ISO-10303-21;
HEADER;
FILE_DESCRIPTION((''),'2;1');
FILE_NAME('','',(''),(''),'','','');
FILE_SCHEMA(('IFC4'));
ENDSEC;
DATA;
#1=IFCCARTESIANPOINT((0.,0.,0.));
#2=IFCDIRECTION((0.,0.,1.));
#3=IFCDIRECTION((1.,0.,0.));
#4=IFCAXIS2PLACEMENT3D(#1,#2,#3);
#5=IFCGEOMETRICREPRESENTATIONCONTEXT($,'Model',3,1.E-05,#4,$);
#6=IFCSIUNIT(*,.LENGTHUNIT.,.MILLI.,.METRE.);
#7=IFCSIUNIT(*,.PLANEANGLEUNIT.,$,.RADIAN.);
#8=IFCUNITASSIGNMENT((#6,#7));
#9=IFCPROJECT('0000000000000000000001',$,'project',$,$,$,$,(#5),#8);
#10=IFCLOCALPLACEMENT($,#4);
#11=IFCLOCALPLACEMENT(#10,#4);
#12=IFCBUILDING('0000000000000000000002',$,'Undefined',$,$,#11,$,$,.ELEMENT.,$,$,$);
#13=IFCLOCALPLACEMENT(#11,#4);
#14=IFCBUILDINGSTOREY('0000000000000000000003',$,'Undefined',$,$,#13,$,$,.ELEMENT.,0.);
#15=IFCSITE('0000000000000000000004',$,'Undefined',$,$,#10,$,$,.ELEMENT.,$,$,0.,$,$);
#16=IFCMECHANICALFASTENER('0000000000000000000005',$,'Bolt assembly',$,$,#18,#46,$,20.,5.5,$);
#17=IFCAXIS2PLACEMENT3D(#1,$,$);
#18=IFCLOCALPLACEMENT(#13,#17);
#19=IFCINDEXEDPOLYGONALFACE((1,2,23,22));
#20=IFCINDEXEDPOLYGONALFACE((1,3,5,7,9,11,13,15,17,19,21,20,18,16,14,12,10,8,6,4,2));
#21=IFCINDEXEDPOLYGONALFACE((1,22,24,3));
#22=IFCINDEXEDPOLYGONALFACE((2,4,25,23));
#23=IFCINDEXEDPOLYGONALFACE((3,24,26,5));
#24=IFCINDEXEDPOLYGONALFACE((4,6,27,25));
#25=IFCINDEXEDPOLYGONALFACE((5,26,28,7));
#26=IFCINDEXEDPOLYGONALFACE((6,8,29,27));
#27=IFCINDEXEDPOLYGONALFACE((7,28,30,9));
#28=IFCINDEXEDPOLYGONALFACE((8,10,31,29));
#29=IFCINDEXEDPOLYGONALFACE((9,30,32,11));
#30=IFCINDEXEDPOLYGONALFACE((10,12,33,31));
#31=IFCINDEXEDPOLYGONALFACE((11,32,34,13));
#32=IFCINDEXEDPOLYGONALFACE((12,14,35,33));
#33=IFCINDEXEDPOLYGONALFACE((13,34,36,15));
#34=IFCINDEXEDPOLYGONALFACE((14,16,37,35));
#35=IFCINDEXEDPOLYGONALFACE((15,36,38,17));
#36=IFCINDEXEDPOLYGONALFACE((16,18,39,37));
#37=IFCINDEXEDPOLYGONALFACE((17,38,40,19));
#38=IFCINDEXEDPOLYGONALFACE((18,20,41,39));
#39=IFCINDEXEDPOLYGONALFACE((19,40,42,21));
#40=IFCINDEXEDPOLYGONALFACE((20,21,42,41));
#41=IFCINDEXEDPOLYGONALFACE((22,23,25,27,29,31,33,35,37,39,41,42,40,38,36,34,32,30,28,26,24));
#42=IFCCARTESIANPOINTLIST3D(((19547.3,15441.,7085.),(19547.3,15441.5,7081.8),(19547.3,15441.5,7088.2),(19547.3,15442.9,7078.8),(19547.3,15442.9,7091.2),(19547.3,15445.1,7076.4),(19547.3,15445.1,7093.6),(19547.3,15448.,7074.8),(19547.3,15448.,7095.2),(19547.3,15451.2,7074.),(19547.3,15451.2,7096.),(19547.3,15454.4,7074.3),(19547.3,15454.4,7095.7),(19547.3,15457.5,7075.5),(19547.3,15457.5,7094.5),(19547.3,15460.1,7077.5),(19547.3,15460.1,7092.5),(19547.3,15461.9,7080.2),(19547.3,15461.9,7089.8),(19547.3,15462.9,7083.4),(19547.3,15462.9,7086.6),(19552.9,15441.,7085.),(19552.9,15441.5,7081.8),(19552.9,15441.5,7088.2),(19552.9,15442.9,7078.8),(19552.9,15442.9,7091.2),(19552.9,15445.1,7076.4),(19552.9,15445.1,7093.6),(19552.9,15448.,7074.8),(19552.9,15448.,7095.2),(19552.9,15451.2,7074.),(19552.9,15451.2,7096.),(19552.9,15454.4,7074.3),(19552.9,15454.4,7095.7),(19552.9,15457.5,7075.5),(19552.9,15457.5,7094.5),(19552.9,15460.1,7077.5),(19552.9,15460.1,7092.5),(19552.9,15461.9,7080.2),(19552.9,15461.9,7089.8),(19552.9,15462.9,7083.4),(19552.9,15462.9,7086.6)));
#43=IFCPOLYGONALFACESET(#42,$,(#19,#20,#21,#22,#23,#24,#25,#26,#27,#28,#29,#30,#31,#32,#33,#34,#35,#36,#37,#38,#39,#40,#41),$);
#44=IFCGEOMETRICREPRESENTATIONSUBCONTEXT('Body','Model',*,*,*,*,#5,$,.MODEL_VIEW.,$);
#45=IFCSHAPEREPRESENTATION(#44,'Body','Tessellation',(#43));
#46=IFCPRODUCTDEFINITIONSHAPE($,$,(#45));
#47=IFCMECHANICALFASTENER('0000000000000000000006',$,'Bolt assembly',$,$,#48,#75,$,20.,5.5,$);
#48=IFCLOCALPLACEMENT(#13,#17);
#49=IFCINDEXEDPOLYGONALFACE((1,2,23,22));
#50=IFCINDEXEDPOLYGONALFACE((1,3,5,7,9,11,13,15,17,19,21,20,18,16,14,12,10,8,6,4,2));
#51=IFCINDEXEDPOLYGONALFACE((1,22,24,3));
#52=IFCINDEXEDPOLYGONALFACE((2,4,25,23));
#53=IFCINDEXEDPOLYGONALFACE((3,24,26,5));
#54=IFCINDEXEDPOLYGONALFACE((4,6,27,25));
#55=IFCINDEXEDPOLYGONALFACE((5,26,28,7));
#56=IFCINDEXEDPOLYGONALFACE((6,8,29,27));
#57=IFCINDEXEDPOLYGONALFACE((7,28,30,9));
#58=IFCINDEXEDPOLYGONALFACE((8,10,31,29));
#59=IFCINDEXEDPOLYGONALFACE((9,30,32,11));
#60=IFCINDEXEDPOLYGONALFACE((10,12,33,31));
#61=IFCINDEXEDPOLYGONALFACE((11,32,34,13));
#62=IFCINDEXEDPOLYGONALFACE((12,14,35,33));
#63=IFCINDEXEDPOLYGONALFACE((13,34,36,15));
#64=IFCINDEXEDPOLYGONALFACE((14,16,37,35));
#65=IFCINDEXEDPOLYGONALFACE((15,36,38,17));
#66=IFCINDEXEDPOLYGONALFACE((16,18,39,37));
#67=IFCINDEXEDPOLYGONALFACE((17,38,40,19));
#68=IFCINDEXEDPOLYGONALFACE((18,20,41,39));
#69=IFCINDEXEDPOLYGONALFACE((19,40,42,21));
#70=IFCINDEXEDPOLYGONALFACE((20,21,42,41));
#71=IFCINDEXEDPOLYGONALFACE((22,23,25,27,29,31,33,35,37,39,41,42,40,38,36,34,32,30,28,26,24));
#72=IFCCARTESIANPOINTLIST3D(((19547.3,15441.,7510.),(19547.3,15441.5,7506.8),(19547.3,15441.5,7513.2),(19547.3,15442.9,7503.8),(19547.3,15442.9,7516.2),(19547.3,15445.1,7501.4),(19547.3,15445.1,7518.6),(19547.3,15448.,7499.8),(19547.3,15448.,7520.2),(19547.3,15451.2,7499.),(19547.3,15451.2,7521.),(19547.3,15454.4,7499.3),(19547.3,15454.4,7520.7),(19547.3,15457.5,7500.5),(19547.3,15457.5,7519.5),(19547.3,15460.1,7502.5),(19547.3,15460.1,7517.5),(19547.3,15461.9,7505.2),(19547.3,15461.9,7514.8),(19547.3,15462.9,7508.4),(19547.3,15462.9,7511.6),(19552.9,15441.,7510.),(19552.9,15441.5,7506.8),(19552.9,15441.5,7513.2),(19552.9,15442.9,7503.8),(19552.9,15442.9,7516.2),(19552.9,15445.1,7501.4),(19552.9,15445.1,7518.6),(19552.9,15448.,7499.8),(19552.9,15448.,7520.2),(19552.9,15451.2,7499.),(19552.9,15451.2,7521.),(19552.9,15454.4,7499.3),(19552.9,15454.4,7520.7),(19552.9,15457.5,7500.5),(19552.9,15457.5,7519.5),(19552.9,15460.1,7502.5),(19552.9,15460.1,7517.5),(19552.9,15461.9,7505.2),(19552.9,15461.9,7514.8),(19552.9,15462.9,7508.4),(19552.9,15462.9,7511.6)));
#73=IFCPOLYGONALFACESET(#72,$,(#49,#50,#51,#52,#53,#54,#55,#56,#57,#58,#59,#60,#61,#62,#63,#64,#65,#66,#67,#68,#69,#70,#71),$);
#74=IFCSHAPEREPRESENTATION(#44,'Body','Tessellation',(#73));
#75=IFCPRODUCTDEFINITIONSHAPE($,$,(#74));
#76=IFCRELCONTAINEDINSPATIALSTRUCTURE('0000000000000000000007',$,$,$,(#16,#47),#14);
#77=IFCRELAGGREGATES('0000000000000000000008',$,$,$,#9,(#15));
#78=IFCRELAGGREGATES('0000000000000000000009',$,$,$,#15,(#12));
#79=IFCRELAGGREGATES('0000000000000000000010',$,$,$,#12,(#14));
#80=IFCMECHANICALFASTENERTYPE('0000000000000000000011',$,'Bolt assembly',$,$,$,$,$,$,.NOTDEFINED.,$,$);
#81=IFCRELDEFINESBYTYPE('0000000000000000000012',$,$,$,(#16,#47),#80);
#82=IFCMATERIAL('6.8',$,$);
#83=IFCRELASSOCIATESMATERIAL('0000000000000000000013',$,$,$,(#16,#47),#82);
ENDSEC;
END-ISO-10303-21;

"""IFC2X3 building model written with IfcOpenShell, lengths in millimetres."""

from ifc_helpers import new_model, si_unit, frame, origin_with_axes, origin_2d_with_axis, place, context, subcontext, project, spatial, circle, extrude, source, transform, mapped, material, type_object, element, save


model = new_model("IFC2X3")

# Units and contexts
model_context = context("Model", 3, precision=1e-05, world=origin_with_axes())
body_context = subcontext(model_context, "Body", "Model", "MODEL_VIEW")
ifc_project = project(units=[si_unit("LENGTHUNIT", "METRE", prefix="MILLI"), si_unit("PLANEANGLEUNIT", "RADIAN")], contexts=[model_context])

# Site, building, storey
site_placement = place(None, origin_with_axes())
site = spatial("IfcSite", under=ifc_project, at=site_placement, Name="Undefined", CompositionType="ELEMENT", RefElevation=0.0)
building_placement = place(site_placement, origin_with_axes())
building = spatial("IfcBuilding", under=site, at=building_placement, Name="Undefined", CompositionType="ELEMENT")
storey_placement = place(building_placement, origin_with_axes())
storey = spatial("IfcBuildingStorey", under=building, at=storey_placement, Name="Undefined", CompositionType="ELEMENT", Elevation=0.0)

# Mechanical fasteners
ifc_material_1 = material(Name="6.8")
mechanical_fastener_type = type_object("IfcMechanicalFastenerType", Name="Bolt assembly")
shared_shape_1 = source(origin_with_axes(), body_context, "Body", "SweptSolid", [
    extrude(circle(Radius=11.0, at=origin_2d_with_axis()), frame((0.0, -2.7, 0.0), z_axis=(0.0, 1.0, 0.0), x_axis=(1.0, 0.0, 0.0)), (0.0, 0.0, 1.0), 5.6),
])
for number, where, z_axis, x_axis, name in (
    (1, (19550.0, 15452.0, 7085.0), (0.0, 0.0, 1.0), (0.0, -1.0, 0.0), "Bolt assembly"),
    (2, (19550.0, 15452.0, 7510.0), (0.0, 0.0, 1.0), (0.0, -1.0, 0.0), "Bolt assembly"),
):
    element("IfcMechanicalFastener", number, at=place(storey_placement, frame(where, z_axis=z_axis, x_axis=x_axis)), inside=storey, type_object=mechanical_fastener_type, material=ifc_material_1, Name=name, NominalDiameter=20.0, NominalLength=5.5, context=body_context, shape_type="MappedRepresentation", body=[
        mapped(shared_shape_1, transform((0.0, 0.0, 0.0))),
    ])

save(model, "model.ifc")
